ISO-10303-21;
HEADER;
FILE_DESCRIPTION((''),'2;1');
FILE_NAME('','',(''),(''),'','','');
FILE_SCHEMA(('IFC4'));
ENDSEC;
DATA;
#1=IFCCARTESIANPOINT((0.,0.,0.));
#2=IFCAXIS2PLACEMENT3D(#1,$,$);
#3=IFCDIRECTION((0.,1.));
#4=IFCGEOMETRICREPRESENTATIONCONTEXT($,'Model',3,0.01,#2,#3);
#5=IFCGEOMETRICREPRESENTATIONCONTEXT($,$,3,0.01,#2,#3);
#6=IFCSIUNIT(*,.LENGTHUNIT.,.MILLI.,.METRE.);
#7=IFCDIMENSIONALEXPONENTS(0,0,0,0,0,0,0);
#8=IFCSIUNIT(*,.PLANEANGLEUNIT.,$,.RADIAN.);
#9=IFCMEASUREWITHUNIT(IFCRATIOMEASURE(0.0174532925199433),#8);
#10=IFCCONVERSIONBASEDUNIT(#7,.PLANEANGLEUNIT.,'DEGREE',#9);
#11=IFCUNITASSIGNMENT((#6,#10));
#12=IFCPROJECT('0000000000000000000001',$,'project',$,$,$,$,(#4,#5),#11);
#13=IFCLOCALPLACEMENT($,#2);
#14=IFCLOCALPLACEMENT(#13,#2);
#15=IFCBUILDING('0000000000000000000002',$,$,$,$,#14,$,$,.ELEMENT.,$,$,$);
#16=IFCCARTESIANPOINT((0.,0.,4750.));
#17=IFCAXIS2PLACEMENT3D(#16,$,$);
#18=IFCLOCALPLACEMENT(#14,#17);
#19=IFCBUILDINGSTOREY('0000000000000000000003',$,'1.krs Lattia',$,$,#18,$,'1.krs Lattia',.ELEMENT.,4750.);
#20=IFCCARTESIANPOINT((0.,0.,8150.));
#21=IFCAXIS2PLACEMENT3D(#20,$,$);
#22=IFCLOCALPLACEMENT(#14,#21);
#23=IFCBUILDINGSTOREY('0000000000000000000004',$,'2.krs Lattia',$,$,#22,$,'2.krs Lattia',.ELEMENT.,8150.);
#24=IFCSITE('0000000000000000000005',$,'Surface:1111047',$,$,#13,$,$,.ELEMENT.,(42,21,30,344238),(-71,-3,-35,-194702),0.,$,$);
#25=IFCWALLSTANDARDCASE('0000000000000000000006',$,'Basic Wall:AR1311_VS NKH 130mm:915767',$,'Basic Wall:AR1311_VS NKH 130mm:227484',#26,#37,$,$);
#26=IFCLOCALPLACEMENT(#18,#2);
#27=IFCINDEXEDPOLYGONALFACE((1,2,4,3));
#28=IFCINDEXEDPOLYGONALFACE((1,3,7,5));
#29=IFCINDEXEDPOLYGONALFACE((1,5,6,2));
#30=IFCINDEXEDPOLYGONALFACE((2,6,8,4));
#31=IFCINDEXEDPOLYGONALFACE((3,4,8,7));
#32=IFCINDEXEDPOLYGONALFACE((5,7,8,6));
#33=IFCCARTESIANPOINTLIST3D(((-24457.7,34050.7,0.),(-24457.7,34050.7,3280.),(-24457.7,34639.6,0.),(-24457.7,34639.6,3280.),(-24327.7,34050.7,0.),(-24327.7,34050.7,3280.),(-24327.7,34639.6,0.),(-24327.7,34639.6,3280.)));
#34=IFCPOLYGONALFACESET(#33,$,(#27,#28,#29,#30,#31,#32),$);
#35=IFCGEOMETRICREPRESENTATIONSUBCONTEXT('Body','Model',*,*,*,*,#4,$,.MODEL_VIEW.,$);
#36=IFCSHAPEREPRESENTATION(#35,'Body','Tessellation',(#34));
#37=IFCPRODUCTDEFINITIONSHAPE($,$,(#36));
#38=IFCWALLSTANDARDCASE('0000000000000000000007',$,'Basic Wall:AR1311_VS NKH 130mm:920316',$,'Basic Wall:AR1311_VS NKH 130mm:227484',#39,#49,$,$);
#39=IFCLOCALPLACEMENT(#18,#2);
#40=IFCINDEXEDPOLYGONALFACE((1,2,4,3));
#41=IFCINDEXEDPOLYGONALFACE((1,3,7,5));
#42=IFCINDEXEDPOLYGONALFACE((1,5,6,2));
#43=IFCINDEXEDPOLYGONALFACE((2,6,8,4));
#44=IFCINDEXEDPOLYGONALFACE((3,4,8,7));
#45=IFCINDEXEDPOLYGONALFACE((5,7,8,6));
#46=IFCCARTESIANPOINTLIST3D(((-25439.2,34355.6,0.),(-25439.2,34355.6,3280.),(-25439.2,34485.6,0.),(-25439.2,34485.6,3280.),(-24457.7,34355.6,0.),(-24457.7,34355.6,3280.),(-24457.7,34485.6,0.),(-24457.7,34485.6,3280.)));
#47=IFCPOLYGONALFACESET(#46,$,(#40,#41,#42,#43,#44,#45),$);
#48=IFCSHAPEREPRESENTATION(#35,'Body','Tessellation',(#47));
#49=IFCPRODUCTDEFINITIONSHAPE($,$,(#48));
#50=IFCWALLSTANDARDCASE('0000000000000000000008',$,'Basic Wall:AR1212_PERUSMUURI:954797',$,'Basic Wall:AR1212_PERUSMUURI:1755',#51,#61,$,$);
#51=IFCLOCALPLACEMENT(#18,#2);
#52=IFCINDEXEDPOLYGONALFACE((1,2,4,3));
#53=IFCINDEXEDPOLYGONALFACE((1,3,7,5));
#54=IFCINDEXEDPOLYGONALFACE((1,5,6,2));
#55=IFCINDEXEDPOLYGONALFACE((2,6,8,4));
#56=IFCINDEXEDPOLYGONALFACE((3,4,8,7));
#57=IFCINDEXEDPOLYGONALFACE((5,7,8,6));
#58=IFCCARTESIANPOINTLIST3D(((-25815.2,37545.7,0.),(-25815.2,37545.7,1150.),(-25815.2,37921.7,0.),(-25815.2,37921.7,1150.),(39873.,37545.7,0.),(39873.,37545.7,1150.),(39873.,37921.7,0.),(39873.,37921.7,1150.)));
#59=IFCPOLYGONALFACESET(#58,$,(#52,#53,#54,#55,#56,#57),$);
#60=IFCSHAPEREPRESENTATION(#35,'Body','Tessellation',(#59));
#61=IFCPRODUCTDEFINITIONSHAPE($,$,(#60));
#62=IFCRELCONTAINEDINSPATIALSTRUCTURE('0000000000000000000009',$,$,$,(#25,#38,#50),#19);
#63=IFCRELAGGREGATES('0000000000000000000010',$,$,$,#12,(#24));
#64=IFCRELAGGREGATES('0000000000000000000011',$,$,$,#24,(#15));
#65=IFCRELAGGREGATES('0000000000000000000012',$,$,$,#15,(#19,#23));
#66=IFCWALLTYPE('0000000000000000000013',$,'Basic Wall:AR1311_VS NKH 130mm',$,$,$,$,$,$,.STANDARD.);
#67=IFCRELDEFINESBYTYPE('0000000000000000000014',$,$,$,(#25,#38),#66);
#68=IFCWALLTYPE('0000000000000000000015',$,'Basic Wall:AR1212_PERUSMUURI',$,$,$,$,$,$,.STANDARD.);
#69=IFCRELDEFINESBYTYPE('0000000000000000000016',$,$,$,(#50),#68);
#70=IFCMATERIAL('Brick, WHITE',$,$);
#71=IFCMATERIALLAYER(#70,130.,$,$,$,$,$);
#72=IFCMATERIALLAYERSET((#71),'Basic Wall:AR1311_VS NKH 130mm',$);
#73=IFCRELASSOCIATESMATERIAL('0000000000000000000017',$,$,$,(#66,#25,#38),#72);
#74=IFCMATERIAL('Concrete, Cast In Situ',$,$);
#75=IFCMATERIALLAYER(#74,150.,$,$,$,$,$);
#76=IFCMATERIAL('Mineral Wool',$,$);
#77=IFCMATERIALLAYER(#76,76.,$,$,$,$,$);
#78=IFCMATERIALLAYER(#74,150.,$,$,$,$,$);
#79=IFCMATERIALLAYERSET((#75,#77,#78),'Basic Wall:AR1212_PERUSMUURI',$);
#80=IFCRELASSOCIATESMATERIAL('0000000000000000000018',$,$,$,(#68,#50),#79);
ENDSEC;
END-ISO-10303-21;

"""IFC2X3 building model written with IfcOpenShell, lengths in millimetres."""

from ifc_helpers import new_model, entity, si_unit, converted_unit, direction, frame, frame_2d, origin, place, context, subcontext, project, spatial, polyline, rectangle, extrude, clip, bounded_halfspace, material, layer, layer_set, layer_usage, type_object, element, save


model = new_model("IFC2X3")

# Units and contexts
model_context = context("Model", 3, precision=0.01, world=origin(), true_north=direction((0.0, 1.0)))
context_of_model = context(None, 3, precision=0.01, world=origin(), true_north=direction((0.0, 1.0)))
body_context = subcontext(model_context, "Body", "Model", "MODEL_VIEW")
ifc_project = project(units=[si_unit("LENGTHUNIT", "METRE", prefix="MILLI"), converted_unit("PLANEANGLEUNIT", "DEGREE", entity("IfcRatioMeasure", 0.0174532925199433), si_unit("PLANEANGLEUNIT", "RADIAN"), dimensions=[0, 0, 0, 0, 0, 0, 0])], contexts=[model_context, context_of_model])

# Site, building, storey
site_placement = place(None, origin())
site = spatial("IfcSite", under=ifc_project, at=site_placement, Name="Surface:1111047", CompositionType="ELEMENT", RefLatitude=(42, 21, 30, 344238), RefLongitude=(-71, -3, -35, -194702), RefElevation=0.0)
building_placement = place(site_placement, origin())
building = spatial("IfcBuilding", under=site, at=building_placement, CompositionType="ELEMENT")
storey_1_placement = place(building_placement, frame((0.0, 0.0, 4750.0)))
storey_1 = spatial("IfcBuildingStorey", under=building, at=storey_1_placement, Name="1.krs Lattia", LongName="1.krs Lattia", CompositionType="ELEMENT", Elevation=4750.0)

# Walls
ifc_material_1 = material(Name="Brick, WHITE")
ifc_layer_1 = layer(ifc_material_1, 130.0)
ifc_layer_set_1 = layer_set([ifc_layer_1], Name="Basic Wall:AR1311_VS NKH 130mm")
ifc_layer_usage_1 = layer_usage(ifc_layer_set_1, "AXIS2", "NEGATIVE", 65.0)
wall_type_1 = type_object("IfcWallType", Name="Basic Wall:AR1311_VS NKH 130mm", PredefinedType="STANDARD", material=ifc_layer_set_1)
wall_1_placement = place(storey_1_placement, frame((-24392.7, 34050.7, 0.0), z_axis=(0.0, 0.0, 1.0), x_axis=(0.0, 1.0, 0.0)))
element("IfcWallStandardCase", 1, at=wall_1_placement, inside=storey_1, type_object=wall_type_1, material=ifc_layer_usage_1, Name="Basic Wall:AR1311_VS NKH 130mm:915767", ObjectType="Basic Wall:AR1311_VS NKH 130mm:227484", context=body_context, shape_type="Clipping", body=[
    clip(extrude(rectangle(XDim=588.9, YDim=130.0, at=frame_2d((294.5, 0.0), x_axis=(-1.0, 0.0))), origin(), (0.0, 0.0, 1.0), 3280.0), bounded_halfspace(frame((0.0, -65.0, 3280.0), z_axis=(0.0, 0.0, -1.0), x_axis=(1.0, 0.0, 0.0)), True, frame((0.0, -65.0, 3280.0)), polyline([(0.0, 0.0), (588.9, 0.0), (588.9, 130.0), (434.9, 130.0), (304.9, 130.0), (0.0, 130.0), (0.0, 0.0)]))),
])
ifc_layer_usage_2 = layer_usage(ifc_layer_set_1, "AXIS2", "NEGATIVE", 65.0)
wall_2_placement = place(storey_1_placement, frame((-25439.2, 34420.6, 0.0)))
element("IfcWallStandardCase", 2, at=wall_2_placement, inside=storey_1, type_object=wall_type_1, material=ifc_layer_usage_2, Name="Basic Wall:AR1311_VS NKH 130mm:920316", ObjectType="Basic Wall:AR1311_VS NKH 130mm:227484", context=body_context, shape_type="Clipping", body=[
    clip(extrude(rectangle(XDim=981.5, YDim=130.0, at=frame_2d((490.7, 0.0), x_axis=(-1.0, 0.0))), origin(), (0.0, 0.0, 1.0), 3280.0), bounded_halfspace(frame((0.0, -65.0, 3280.0), z_axis=(0.0, 0.0, -1.0), x_axis=(0.0, 1.0, 0.0)), True, frame((0.0, -65.0, 3280.0)), polyline([(0.0, 0.0), (981.5, 0.0), (981.5, 130.0), (0.0, 130.0), (0.0, 0.0)]))),
])

# Shared definitions
storey_2_placement = place(building_placement, frame((0.0, 0.0, 8150.0)))
storey_2 = spatial("IfcBuildingStorey", under=building, at=storey_2_placement, Name="2.krs Lattia", LongName="2.krs Lattia", CompositionType="ELEMENT", Elevation=8150.0)

# Wall
ifc_material_2 = material(Name="Concrete, Cast In Situ")
ifc_layer_2 = layer(ifc_material_2, 150.0)
ifc_material_3 = material(Name="Mineral Wool")
ifc_layer_3 = layer(ifc_material_3, 76.0)
ifc_layer_4 = layer(ifc_material_2, 150.0)
ifc_layer_set_2 = layer_set([ifc_layer_2, ifc_layer_3, ifc_layer_4], Name="Basic Wall:AR1212_PERUSMUURI")
ifc_layer_usage_3 = layer_usage(ifc_layer_set_2, "AXIS2", "NEGATIVE", 188.0)
wall_type_2 = type_object("IfcWallType", Name="Basic Wall:AR1212_PERUSMUURI", PredefinedType="STANDARD", material=ifc_layer_set_2)
wall_3_placement = place(storey_1_placement, frame((-25815.2, 37733.7, 0.0)))
element("IfcWallStandardCase", 3, at=wall_3_placement, inside=storey_1, type_object=wall_type_2, material=ifc_layer_usage_3, Name="Basic Wall:AR1212_PERUSMUURI:954797", ObjectType="Basic Wall:AR1212_PERUSMUURI:1755", context=body_context, shape_type="SweptSolid", body=[
    extrude(rectangle(XDim=65688.2, YDim=376.0, at=frame_2d((32844.1, 0.0), x_axis=(-1.0, 0.0))), origin(), (0.0, 0.0, 1.0), 1150.0),
])

save(model, "model.ifc")
